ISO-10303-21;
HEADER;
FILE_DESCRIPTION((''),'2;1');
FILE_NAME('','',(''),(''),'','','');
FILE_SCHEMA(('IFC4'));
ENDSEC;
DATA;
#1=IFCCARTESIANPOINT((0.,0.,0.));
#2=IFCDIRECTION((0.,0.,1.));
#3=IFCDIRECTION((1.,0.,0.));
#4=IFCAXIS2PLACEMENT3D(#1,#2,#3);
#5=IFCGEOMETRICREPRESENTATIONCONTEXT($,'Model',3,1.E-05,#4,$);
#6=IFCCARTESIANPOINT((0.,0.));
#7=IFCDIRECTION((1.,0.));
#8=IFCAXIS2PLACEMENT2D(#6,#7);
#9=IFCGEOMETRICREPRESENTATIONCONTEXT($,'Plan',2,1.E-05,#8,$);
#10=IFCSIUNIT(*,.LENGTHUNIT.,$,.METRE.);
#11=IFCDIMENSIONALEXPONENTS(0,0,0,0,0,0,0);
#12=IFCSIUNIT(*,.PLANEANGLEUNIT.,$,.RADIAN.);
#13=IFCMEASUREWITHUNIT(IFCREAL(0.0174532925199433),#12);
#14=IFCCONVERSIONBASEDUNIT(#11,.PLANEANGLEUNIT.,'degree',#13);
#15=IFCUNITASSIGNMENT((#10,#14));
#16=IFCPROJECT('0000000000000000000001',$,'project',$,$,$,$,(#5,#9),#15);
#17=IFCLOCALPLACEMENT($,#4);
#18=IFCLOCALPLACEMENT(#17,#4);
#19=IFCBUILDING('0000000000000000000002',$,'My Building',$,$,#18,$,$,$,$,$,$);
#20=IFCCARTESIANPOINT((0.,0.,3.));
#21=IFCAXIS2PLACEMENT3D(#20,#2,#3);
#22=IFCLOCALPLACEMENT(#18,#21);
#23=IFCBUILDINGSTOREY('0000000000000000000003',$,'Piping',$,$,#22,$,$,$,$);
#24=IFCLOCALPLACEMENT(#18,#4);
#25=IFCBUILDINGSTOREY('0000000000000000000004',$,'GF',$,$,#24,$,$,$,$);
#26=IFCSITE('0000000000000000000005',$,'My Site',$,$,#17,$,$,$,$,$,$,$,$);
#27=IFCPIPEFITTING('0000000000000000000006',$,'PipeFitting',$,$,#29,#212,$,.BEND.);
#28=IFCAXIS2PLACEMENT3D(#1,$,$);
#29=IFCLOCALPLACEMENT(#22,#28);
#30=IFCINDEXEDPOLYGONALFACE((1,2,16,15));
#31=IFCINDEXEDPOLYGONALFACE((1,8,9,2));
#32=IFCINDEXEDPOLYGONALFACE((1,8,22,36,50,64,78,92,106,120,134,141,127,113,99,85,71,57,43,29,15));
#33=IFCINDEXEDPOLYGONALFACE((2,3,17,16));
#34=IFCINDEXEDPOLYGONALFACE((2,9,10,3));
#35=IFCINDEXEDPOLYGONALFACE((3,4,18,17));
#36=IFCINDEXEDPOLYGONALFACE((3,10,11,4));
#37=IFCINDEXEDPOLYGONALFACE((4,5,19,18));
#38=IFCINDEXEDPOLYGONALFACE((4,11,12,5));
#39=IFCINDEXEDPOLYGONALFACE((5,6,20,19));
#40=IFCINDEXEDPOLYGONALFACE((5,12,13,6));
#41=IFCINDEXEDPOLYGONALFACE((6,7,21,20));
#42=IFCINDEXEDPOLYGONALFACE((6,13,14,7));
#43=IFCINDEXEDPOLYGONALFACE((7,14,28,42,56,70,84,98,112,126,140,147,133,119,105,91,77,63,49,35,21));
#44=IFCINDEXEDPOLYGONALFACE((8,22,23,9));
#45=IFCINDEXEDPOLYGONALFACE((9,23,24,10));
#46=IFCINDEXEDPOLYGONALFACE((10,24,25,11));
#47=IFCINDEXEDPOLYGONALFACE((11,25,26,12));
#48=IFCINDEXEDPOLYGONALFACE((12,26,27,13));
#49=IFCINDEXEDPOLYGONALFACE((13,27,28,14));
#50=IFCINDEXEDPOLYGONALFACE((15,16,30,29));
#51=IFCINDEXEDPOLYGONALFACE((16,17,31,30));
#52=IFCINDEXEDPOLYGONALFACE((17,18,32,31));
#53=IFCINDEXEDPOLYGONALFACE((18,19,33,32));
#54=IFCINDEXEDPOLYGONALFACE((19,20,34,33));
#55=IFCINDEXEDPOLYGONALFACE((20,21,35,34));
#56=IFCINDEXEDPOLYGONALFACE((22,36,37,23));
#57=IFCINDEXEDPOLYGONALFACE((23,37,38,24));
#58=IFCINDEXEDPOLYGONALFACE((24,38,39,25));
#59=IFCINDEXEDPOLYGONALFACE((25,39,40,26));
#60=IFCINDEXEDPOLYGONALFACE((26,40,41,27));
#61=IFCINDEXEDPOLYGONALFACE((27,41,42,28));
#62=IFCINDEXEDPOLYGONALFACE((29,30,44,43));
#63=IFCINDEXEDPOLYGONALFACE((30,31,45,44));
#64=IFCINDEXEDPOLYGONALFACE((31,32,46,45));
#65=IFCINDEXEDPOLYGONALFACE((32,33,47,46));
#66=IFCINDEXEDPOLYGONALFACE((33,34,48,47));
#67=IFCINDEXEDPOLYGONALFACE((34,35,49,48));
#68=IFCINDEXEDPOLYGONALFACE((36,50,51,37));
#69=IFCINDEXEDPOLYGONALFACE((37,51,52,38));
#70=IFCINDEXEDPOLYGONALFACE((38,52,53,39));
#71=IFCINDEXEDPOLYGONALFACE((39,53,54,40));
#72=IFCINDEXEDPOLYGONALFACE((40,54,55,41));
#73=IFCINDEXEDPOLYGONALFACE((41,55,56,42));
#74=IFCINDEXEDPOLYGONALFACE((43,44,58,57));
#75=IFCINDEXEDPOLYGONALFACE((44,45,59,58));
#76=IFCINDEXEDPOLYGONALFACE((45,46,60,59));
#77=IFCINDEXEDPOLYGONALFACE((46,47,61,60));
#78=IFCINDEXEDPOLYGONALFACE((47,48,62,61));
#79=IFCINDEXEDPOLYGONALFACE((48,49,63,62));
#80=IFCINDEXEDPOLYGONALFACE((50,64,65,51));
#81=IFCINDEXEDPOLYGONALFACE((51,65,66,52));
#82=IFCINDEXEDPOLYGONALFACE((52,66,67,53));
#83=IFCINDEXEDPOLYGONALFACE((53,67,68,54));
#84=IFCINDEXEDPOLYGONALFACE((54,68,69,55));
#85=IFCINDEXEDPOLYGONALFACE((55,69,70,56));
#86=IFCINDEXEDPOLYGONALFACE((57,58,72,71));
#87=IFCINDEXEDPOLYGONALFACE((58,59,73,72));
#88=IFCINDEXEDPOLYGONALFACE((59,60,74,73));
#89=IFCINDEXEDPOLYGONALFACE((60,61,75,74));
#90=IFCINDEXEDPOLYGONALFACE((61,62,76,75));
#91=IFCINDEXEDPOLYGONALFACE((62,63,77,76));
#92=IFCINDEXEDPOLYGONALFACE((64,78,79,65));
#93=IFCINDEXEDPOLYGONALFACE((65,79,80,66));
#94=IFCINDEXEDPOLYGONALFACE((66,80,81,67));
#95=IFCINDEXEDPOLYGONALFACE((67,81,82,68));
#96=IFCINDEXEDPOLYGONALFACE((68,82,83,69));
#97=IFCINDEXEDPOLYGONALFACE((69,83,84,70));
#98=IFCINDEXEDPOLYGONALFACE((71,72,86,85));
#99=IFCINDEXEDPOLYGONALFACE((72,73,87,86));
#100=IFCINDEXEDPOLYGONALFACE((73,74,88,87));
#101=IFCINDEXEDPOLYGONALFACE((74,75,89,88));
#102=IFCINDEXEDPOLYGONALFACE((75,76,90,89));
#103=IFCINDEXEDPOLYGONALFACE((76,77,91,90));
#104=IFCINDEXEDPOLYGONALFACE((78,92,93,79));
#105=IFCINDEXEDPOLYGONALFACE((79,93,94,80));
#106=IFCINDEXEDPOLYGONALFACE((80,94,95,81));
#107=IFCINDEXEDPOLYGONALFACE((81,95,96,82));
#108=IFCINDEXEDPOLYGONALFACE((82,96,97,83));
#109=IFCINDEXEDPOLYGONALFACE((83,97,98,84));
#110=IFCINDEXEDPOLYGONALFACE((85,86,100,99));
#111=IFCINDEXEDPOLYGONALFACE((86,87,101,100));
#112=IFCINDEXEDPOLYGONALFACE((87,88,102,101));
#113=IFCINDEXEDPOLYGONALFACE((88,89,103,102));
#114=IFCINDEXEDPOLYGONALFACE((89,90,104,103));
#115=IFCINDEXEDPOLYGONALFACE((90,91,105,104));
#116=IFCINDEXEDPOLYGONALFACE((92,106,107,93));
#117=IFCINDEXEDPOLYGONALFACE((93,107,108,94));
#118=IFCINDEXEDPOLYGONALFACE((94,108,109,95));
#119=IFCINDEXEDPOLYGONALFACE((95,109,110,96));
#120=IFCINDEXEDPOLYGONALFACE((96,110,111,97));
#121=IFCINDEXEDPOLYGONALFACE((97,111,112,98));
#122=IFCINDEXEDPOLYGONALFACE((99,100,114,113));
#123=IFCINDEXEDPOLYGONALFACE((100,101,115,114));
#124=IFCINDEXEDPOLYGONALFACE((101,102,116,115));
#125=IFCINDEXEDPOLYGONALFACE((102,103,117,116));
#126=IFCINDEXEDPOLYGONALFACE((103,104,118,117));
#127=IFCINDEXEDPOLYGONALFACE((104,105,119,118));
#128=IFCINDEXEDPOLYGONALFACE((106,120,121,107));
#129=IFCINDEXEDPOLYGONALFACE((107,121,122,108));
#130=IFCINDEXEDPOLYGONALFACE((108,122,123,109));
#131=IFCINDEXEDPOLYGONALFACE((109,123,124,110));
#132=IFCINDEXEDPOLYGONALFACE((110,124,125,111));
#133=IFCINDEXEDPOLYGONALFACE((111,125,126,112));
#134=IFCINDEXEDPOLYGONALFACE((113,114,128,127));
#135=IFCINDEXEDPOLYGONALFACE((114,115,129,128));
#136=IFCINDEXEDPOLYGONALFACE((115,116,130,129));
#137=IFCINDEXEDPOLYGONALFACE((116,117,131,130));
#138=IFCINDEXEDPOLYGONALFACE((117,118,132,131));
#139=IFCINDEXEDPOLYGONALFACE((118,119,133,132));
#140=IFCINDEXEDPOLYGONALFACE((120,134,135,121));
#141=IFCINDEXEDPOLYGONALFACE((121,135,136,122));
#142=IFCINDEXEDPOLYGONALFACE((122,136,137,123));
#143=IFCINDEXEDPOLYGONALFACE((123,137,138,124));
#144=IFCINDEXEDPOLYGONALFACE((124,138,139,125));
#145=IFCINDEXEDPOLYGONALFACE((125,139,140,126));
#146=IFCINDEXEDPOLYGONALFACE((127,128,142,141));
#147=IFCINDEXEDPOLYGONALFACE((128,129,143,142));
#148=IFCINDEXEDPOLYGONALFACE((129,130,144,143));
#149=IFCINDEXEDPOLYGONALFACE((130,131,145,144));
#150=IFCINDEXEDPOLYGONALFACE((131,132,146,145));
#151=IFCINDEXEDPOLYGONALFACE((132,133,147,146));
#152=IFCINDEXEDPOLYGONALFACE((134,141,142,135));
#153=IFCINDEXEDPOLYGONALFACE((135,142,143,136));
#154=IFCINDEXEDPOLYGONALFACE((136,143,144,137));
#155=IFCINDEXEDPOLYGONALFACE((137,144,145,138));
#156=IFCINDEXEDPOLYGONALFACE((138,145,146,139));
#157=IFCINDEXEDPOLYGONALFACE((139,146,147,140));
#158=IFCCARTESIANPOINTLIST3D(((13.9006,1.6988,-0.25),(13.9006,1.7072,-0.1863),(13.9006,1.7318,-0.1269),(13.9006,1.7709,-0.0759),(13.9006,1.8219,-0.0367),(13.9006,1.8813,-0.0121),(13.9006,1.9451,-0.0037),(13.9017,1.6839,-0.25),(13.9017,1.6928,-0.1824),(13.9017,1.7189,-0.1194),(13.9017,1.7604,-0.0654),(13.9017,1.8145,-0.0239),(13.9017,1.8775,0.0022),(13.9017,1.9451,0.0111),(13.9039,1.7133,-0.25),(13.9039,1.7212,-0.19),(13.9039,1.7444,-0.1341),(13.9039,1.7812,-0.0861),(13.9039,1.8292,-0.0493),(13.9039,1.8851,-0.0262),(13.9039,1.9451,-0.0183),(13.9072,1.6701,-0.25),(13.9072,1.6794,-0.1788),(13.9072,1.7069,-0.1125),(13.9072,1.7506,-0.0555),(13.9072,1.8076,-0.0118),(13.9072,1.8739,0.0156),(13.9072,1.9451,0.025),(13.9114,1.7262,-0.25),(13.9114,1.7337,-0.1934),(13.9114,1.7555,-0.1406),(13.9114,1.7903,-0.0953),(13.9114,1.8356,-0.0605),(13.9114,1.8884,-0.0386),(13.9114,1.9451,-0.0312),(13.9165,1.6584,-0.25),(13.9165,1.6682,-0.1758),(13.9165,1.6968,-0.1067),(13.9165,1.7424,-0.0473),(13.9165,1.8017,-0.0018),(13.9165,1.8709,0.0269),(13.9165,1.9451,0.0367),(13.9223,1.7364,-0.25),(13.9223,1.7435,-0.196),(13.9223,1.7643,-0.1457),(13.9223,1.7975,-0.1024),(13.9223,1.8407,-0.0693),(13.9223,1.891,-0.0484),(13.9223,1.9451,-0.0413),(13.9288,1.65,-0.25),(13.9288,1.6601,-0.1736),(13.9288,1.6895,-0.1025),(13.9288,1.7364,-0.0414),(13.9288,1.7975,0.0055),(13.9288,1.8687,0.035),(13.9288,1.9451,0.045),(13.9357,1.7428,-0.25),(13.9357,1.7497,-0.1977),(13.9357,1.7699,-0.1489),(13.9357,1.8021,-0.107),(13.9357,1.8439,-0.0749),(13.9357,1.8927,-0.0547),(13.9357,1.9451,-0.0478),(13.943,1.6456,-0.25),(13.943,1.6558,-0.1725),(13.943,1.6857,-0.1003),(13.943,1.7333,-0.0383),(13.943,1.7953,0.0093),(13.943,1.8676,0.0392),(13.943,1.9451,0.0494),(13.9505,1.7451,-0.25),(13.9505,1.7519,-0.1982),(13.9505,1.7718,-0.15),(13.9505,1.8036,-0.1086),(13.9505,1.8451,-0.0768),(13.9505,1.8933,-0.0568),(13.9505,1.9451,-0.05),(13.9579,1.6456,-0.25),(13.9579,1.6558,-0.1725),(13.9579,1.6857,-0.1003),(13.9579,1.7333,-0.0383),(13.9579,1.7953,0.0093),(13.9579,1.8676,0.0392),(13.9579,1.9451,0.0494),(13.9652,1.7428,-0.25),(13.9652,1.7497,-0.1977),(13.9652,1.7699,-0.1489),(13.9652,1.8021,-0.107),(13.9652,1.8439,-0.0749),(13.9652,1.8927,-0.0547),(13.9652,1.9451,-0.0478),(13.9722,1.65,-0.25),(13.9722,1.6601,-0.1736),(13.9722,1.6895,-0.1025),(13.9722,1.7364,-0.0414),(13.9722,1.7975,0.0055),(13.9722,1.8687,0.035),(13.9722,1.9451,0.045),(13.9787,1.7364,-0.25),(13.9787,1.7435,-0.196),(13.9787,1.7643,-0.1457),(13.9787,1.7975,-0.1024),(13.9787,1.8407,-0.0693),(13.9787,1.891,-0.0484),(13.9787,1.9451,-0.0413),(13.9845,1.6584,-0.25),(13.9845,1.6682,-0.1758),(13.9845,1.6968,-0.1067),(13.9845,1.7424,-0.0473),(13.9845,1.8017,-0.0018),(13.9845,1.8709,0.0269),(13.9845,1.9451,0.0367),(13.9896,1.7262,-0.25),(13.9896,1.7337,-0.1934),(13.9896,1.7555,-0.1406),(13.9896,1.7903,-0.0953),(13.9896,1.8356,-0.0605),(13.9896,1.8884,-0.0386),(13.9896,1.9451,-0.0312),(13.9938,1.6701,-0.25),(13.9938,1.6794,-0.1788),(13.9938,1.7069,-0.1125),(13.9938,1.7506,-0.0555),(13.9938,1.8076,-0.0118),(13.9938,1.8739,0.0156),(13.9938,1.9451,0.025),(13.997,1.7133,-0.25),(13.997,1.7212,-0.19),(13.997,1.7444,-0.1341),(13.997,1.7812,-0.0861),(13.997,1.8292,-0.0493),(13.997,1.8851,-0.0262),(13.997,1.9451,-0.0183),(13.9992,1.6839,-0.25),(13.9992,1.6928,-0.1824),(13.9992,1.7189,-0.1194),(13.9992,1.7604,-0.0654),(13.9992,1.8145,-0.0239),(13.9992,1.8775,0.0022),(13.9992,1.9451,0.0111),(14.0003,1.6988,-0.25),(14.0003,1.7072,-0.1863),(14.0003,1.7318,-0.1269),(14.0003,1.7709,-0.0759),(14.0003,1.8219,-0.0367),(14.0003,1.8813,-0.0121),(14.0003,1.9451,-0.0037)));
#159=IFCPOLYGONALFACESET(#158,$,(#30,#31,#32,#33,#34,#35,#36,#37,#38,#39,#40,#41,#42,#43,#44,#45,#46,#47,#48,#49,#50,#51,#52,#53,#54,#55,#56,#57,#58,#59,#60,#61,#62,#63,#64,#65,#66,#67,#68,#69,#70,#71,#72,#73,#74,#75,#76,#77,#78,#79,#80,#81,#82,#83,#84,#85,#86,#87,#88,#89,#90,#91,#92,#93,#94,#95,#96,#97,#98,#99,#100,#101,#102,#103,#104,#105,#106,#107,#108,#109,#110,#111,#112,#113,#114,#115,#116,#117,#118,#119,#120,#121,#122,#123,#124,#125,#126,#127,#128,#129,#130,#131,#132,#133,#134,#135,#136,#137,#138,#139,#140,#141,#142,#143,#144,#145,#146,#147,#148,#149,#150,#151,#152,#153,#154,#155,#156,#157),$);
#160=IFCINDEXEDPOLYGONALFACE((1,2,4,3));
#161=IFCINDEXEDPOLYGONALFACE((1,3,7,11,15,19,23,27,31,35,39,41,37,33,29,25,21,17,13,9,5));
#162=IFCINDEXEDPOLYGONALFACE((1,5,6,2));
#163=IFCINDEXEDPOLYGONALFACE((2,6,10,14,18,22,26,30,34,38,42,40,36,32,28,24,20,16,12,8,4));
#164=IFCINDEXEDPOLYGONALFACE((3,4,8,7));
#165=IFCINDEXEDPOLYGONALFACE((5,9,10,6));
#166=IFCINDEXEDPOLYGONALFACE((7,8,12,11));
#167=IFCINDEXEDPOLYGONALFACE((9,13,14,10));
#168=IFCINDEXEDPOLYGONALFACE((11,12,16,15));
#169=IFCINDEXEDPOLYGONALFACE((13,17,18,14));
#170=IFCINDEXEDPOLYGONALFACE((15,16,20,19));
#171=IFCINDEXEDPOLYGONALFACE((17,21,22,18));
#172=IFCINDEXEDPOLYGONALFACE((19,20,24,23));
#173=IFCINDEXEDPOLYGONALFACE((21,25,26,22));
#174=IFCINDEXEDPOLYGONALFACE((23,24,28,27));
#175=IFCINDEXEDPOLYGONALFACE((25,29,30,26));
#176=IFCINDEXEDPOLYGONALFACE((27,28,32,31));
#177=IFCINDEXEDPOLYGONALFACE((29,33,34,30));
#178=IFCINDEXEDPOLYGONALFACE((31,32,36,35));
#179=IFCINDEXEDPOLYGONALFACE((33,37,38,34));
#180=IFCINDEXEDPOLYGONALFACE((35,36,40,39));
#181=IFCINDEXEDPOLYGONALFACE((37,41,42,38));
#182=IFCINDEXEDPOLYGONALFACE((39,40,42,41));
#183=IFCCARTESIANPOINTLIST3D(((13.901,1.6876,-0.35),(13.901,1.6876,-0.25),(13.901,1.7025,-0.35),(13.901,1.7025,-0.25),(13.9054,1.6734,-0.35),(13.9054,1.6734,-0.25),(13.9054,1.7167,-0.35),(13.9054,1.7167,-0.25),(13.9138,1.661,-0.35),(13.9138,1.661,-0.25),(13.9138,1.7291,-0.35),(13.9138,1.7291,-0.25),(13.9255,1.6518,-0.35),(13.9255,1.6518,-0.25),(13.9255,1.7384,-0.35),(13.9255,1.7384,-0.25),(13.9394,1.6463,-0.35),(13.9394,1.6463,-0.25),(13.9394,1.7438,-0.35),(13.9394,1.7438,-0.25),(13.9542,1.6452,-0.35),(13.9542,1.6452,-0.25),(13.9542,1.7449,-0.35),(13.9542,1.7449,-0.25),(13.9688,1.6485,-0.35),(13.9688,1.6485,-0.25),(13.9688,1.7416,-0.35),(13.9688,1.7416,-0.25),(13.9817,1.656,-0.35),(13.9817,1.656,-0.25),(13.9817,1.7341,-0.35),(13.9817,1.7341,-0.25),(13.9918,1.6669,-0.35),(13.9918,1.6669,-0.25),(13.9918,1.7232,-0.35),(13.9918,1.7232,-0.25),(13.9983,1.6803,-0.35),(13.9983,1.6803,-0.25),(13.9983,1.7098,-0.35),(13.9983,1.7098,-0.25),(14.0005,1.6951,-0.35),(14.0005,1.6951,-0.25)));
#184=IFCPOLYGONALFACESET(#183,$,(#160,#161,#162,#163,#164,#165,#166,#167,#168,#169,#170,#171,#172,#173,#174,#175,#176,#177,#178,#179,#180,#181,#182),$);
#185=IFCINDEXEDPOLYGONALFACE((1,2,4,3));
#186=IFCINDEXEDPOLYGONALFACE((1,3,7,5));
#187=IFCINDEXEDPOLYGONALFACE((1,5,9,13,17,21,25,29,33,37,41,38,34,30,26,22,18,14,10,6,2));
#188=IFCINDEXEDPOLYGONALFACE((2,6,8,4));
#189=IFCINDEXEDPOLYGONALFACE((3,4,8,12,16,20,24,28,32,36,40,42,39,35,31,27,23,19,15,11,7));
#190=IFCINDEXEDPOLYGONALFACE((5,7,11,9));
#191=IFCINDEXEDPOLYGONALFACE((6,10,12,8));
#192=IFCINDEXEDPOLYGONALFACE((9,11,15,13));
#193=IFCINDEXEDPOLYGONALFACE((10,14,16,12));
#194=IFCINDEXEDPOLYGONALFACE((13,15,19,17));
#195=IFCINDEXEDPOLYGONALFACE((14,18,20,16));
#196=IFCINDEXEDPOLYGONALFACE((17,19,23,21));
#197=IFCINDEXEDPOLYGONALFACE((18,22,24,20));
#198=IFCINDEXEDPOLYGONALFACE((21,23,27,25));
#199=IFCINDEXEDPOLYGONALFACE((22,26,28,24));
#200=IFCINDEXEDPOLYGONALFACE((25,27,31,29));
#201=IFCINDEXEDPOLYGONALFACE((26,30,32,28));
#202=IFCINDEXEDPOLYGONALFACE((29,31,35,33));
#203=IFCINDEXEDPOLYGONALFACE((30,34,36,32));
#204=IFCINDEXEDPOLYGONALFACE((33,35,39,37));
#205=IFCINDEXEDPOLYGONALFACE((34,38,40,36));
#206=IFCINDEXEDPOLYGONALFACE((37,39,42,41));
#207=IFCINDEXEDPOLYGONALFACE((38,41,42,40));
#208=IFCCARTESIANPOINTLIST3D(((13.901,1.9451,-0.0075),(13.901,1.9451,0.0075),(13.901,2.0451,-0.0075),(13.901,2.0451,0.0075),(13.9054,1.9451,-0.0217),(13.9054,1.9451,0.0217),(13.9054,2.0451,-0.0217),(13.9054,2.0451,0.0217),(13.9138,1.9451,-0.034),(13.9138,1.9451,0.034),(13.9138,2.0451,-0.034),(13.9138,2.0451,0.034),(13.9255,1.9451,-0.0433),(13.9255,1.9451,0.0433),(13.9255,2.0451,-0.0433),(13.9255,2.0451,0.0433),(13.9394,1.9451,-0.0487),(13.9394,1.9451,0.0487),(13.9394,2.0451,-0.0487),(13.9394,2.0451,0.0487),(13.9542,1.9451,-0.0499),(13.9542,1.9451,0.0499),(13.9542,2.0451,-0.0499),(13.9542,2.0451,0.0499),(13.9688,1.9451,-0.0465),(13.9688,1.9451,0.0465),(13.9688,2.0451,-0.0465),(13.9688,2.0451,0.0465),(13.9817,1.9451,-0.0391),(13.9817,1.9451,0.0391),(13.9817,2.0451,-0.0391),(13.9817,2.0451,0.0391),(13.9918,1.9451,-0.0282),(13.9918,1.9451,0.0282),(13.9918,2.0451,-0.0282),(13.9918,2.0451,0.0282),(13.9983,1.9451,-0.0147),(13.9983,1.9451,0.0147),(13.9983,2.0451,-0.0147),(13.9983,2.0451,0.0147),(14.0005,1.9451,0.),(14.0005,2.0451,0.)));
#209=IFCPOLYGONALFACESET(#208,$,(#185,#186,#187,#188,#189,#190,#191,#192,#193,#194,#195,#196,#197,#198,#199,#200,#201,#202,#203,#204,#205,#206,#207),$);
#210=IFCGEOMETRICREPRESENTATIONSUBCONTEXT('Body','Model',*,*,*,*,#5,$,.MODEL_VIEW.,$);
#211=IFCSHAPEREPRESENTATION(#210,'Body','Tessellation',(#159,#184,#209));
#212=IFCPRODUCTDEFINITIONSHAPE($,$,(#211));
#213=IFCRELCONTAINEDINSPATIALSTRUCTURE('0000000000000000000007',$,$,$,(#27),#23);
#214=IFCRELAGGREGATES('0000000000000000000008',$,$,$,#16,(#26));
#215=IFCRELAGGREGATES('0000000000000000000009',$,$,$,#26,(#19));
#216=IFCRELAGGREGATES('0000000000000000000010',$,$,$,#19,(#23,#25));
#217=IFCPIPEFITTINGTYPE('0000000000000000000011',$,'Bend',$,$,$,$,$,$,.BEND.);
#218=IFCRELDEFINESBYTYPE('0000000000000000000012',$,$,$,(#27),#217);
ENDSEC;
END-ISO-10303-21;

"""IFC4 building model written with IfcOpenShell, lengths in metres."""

from ifc_helpers import new_model, entity, si_unit, converted_unit, frame, origin_with_axes, origin_2d_with_axis, place, context, subcontext, project, spatial, circle, extrude, source, transform, mapped, type_object, type_shapes, element, save


model = new_model("IFC4")

# Units and contexts
model_context = context("Model", 3, precision=1e-05, world=origin_with_axes())
plan_context = context("Plan", 2, precision=1e-05, world=origin_2d_with_axis())
body_context_1 = subcontext(model_context, "Body", "Model", "MODEL_VIEW")
ifc_project = project(units=[si_unit("LENGTHUNIT", "METRE"), converted_unit("PLANEANGLEUNIT", "degree", entity("IfcReal", 0.0174532925199433), si_unit("PLANEANGLEUNIT", "RADIAN"), dimensions=[0, 0, 0, 0, 0, 0, 0])], contexts=[model_context, plan_context])

# Site, building, storey
site_placement = place(None, origin_with_axes())
site = spatial("IfcSite", under=ifc_project, at=site_placement, Name="My Site")
building_placement = place(site_placement, origin_with_axes())
building = spatial("IfcBuilding", under=site, at=building_placement, Name="My Building")
storey_1_placement = place(building_placement, frame((0.0, 0.0, 3.0), z_axis=(0.0, 0.0, 1.0), x_axis=(1.0, 0.0, 0.0)))
storey_1 = spatial("IfcBuildingStorey", under=building, at=storey_1_placement, Name="Piping")

# Shared definitions
storey_2_placement = place(building_placement, origin_with_axes())
storey_2 = spatial("IfcBuildingStorey", under=building, at=storey_2_placement, Name="GF")

# Pipe fitting
pipe_fitting_type_1 = type_object("IfcPipeFittingType", Name="Bend", PredefinedType="BEND")
shared_shape_1 = source(origin_with_axes(), body_context_1, "Body", "SolidModel", [
    entity("IfcSweptDiskSolid", entity("IfcIndexedPolyCurve", entity("IfcCartesianPointList3D", [[0.0, 0.0, -0.1], [0.0, -0.0732, -0.2768], [0.0, -0.25, -0.35]]), [entity("IfcArcIndex", [1, 2, 3])]), 0.05),
    extrude(circle(Radius=0.05), origin_with_axes(), (0.0, 0.0, -1.0), 0.1),
    extrude(circle(Radius=0.05), frame((0.0, -0.25, -0.35), z_axis=(0.0, -1.0, 0.0), x_axis=(1.0, 0.0, 0.0)), (0.0, 0.0, 1.0), 0.1),
])
type_shapes(pipe_fitting_type_1, [shared_shape_1])
for number, where, z_axis, x_axis, name in (
    (1, (13.9505, 1.6951, -0.35), (0.0, 0.0, -1.0), (1.0, 0.0, 0.0), "PipeFitting"),
):
    element("IfcPipeFitting", number, at=place(storey_1_placement, frame(where, z_axis=z_axis, x_axis=x_axis)), inside=storey_1, type_object=pipe_fitting_type_1, Name=name, PredefinedType="BEND", context=body_context_1, shape_type="MappedRepresentation", body=[
        mapped(shared_shape_1, transform((0.0, 0.0, 0.0), x_axis=(1.0, 0.0, 0.0), y_axis=(0.0, 1.0, 0.0), z_axis=(0.0, 0.0, 1.0), scale=1.0)),
    ])

save(model, "model.ifc")
